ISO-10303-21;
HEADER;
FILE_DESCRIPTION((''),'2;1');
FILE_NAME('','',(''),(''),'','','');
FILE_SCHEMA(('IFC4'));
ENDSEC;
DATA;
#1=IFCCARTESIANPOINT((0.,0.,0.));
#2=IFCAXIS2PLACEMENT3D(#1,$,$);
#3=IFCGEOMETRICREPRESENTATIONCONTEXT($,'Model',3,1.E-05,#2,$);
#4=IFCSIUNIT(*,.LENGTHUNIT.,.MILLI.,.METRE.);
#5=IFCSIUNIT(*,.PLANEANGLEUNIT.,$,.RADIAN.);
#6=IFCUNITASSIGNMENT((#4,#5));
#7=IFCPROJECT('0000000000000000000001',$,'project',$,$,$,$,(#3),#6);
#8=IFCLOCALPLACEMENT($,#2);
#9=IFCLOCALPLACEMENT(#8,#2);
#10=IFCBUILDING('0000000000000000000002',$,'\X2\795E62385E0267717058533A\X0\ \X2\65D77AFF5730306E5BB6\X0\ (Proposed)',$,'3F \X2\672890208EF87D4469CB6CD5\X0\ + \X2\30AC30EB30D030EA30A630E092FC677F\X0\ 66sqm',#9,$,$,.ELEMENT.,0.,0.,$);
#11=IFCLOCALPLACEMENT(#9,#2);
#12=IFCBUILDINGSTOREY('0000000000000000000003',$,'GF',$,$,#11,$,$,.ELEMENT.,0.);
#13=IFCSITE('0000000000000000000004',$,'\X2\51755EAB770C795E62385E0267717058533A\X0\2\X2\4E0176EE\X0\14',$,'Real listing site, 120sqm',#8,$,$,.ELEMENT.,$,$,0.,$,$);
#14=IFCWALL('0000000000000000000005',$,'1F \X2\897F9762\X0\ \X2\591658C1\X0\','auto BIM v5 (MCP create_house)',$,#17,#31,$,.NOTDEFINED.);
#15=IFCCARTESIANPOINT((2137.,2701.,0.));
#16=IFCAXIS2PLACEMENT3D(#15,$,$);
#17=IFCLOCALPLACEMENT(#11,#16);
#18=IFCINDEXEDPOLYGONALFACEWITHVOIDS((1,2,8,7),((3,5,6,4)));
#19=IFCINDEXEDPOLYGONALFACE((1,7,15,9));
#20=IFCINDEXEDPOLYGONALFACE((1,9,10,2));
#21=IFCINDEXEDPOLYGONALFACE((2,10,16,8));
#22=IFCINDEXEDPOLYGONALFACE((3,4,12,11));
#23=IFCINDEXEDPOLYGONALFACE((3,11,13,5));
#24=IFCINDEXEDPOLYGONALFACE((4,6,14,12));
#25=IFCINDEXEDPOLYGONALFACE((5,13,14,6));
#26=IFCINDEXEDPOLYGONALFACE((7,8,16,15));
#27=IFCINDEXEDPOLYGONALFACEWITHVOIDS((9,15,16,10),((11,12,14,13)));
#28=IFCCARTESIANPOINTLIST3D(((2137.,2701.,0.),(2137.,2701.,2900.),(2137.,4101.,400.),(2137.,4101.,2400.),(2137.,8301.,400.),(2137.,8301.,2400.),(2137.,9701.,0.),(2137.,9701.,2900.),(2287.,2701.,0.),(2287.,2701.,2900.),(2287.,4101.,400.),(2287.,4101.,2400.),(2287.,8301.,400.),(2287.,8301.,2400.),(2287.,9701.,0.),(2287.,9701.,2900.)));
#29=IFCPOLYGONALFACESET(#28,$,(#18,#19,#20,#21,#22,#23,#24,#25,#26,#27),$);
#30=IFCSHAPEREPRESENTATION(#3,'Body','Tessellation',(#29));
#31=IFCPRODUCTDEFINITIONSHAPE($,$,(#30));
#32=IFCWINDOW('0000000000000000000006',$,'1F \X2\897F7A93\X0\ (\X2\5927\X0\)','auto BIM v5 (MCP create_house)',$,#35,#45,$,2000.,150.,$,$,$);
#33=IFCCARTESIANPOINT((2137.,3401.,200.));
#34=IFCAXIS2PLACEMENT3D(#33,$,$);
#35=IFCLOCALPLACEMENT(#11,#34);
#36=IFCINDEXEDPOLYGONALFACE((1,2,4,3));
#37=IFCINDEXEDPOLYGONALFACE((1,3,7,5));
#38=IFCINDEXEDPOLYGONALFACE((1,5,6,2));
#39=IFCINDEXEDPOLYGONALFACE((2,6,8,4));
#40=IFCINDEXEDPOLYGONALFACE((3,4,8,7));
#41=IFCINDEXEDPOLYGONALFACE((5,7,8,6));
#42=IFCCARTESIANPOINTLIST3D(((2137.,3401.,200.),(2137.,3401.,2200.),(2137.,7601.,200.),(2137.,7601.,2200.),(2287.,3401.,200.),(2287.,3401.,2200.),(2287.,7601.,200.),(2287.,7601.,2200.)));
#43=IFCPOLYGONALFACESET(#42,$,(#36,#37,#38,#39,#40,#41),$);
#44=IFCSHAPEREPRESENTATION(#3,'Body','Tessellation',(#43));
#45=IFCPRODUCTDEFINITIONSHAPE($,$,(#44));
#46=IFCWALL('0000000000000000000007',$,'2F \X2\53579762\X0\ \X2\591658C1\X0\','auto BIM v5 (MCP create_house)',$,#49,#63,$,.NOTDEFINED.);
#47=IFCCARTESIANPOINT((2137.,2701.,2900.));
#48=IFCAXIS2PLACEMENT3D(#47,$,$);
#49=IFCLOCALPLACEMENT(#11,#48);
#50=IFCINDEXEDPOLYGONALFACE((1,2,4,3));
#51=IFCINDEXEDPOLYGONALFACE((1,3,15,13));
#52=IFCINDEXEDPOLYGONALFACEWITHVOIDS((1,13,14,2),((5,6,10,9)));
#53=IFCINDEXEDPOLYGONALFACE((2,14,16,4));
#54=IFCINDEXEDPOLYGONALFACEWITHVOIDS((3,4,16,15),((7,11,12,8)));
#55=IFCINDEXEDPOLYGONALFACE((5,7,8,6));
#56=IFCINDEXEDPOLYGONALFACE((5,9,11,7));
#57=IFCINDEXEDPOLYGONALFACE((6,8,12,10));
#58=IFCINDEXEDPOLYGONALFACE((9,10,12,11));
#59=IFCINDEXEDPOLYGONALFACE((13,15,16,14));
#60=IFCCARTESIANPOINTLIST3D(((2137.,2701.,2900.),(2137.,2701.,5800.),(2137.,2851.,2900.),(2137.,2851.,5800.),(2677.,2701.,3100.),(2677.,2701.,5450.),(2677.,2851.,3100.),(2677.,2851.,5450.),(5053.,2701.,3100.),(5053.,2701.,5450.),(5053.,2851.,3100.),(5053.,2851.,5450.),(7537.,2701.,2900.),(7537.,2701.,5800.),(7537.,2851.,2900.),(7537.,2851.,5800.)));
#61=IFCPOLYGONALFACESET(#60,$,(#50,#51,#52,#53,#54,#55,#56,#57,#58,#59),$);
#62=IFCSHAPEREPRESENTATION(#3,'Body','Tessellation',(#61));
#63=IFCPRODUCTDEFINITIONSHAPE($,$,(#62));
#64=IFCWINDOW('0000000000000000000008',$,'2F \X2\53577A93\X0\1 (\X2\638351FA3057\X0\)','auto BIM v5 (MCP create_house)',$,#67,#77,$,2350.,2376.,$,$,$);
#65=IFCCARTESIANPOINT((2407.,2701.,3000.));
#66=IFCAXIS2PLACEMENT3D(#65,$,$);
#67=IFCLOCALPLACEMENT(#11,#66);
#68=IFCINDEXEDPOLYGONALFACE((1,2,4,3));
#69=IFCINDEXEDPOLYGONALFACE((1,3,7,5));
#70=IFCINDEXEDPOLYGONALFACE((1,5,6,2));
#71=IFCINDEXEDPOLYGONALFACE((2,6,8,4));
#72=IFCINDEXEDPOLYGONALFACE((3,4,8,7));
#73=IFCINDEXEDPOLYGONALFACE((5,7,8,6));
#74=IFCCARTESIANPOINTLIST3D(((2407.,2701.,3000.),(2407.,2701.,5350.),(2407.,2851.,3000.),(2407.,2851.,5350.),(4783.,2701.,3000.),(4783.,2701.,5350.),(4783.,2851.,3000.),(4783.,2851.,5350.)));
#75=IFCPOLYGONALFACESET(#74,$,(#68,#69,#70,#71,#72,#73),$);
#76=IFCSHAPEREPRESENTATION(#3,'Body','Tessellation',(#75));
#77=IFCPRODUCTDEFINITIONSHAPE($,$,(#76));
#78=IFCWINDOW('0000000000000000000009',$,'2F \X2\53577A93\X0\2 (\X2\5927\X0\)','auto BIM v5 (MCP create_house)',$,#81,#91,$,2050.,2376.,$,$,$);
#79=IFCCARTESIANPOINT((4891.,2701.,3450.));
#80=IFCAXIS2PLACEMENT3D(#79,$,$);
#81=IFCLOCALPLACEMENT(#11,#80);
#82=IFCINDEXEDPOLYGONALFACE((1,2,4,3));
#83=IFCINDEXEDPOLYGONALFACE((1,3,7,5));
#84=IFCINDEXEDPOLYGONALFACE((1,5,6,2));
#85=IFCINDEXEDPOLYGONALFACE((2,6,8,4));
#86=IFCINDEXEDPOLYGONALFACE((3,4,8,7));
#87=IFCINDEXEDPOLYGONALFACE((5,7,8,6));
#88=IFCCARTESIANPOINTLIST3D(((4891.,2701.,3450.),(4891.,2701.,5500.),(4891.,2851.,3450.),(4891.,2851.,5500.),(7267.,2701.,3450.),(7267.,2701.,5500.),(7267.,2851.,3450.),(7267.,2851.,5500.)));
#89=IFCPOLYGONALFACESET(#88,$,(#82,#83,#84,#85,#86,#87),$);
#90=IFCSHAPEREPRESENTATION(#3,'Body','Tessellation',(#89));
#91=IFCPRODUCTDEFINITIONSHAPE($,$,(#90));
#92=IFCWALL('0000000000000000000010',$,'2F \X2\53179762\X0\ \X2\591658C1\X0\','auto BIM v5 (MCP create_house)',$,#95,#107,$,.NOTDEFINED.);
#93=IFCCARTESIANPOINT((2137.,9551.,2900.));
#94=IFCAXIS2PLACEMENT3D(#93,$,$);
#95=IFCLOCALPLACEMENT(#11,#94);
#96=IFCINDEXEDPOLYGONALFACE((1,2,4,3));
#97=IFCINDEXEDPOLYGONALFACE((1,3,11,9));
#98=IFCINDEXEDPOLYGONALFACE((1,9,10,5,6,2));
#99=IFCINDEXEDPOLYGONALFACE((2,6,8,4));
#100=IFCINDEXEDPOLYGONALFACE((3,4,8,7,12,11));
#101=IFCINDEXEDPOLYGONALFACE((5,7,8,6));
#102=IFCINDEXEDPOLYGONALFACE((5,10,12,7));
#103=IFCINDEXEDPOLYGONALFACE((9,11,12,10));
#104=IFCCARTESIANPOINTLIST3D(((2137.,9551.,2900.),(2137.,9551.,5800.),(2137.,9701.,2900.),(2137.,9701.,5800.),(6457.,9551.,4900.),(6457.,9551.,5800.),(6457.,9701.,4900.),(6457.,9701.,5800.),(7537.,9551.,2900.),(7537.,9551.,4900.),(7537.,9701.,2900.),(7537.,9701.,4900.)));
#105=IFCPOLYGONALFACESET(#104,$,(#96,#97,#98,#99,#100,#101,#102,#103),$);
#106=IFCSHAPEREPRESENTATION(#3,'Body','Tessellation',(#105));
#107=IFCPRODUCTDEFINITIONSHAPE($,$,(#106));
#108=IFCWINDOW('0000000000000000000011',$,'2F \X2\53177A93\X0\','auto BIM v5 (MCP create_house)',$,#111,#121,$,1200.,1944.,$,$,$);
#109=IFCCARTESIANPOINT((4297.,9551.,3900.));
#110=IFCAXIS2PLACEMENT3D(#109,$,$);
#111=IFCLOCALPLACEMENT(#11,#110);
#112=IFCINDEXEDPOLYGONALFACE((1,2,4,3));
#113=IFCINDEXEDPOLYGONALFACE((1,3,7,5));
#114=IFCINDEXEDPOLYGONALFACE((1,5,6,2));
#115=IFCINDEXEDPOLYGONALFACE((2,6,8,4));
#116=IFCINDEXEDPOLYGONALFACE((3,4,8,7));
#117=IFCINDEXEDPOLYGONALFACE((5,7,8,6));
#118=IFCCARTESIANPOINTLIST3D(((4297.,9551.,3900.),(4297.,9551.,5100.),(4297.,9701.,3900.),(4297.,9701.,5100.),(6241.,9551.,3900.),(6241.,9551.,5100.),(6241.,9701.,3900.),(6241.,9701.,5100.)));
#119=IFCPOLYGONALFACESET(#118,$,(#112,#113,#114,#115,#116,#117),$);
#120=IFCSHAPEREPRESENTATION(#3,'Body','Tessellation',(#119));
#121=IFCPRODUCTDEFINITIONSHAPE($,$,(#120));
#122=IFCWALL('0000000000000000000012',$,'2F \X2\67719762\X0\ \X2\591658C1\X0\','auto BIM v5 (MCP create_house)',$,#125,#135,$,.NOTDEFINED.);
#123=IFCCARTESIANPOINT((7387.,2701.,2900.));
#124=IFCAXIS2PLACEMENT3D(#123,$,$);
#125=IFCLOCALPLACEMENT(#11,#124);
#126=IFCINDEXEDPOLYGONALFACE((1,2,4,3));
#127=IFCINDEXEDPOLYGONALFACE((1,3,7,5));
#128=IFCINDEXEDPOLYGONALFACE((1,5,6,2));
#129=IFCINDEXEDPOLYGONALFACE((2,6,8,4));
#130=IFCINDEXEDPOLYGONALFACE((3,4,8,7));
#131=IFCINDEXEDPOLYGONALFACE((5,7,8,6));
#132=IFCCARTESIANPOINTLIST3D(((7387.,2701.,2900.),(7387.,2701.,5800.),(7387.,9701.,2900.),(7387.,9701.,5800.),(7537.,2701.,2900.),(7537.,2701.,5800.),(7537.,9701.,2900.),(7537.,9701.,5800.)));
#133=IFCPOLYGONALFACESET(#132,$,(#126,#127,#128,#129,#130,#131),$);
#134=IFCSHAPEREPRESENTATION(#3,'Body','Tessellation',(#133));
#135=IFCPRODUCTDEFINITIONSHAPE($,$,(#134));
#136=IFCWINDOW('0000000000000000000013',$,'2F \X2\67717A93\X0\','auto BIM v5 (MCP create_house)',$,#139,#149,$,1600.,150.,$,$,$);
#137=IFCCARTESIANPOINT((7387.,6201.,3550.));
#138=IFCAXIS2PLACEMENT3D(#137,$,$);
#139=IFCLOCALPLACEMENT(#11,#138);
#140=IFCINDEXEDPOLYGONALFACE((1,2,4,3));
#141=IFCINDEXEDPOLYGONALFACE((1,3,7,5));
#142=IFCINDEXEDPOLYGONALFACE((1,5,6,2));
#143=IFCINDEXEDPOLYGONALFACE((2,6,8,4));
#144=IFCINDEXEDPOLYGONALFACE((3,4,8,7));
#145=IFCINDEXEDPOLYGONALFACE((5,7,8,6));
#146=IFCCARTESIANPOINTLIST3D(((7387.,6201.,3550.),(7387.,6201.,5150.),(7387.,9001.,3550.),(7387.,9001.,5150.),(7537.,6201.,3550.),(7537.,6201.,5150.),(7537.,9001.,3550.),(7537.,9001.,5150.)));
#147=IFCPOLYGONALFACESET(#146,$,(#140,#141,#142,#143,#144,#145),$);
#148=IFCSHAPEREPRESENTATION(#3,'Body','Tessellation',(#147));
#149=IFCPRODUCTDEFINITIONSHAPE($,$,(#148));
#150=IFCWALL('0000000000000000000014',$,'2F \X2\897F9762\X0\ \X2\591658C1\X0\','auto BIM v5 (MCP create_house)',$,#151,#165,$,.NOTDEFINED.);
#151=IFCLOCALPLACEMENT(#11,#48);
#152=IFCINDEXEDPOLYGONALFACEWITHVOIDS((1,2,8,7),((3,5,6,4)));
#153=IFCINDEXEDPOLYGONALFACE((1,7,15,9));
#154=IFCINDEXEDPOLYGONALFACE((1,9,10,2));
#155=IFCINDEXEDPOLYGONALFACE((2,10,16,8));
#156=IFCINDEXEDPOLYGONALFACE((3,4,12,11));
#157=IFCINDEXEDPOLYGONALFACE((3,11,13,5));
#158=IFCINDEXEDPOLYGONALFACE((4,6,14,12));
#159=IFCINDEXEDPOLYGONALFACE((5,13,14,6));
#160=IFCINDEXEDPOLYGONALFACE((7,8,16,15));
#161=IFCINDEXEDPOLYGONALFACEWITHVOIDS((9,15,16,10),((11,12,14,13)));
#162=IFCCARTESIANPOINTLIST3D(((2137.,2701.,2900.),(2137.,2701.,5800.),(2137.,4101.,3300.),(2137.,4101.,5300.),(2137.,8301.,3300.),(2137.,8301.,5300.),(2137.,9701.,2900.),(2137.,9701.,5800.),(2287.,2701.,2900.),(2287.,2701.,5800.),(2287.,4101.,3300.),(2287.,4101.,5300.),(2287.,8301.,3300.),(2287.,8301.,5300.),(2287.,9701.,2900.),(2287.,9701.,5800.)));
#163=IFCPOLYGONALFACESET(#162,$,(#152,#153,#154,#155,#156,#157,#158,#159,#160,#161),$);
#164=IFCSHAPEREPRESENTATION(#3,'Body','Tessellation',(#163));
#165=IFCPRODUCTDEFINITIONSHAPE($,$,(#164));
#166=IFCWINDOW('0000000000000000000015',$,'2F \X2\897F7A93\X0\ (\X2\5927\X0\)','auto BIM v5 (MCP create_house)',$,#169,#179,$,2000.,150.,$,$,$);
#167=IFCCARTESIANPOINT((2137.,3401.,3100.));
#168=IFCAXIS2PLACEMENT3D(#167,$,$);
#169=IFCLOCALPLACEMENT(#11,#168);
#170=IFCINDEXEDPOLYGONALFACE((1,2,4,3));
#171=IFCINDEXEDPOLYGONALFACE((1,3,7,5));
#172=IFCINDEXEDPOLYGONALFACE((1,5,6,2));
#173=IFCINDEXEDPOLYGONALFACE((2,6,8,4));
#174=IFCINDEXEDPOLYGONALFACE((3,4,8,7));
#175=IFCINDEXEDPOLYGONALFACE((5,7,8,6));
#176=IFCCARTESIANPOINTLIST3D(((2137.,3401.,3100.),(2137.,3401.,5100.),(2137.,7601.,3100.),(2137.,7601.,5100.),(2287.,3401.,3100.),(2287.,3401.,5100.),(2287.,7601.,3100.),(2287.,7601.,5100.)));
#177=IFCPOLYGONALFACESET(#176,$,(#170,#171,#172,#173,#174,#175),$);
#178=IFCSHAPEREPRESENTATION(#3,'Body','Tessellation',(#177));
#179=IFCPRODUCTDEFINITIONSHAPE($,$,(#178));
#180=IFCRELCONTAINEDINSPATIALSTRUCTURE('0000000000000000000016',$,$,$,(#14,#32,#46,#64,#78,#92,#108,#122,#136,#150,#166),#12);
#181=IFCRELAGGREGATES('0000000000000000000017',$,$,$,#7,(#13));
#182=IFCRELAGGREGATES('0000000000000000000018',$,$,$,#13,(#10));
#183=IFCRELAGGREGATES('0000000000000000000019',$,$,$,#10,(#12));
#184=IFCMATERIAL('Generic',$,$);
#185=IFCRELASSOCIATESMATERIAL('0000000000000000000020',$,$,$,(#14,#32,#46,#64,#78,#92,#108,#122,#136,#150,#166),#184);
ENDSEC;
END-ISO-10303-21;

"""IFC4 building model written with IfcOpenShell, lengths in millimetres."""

from ifc_helpers import new_model, si_unit, frame, frame_2d, origin, place, context, project, spatial, rectangle, extrude, material, element, fill, save


model = new_model("IFC4")

# Units and contexts
model_context = context("Model", 3, precision=1e-05, world=origin())
ifc_project = project(units=[si_unit("LENGTHUNIT", "METRE", prefix="MILLI"), si_unit("PLANEANGLEUNIT", "RADIAN")], contexts=[model_context])

# Site, building, storey
site_placement = place(None, origin())
site = spatial("IfcSite", under=ifc_project, at=site_placement, Name="兵庫県神戸市東灘区2丁目14", ObjectType="Real listing site, 120sqm", CompositionType="ELEMENT", RefElevation=0.0)
building_placement = place(site_placement, origin())
building = spatial("IfcBuilding", under=site, at=building_placement, Name="神戸市東灘区 旗竿地の家 (Proposed)", ObjectType="3F 木造軸組構法 + ガルバリウム鋼板 66sqm", CompositionType="ELEMENT", ElevationOfRefHeight=0.0, ElevationOfTerrain=0.0)
storey_placement = place(building_placement, origin())
storey = spatial("IfcBuildingStorey", under=building, at=storey_placement, Name="GF", CompositionType="ELEMENT", Elevation=0.0)

# Shared definitions
ifc_material = material(Name="Generic")

# Wall, opening, window
wall_1_placement = place(storey_placement, frame((2137.0, 2701.0, 0.0)))
wall_1 = element("IfcWall", 1, at=wall_1_placement, inside=storey, material=ifc_material, Name="1F 西面 外壁", Description="auto BIM v5 (MCP create_house)", PredefinedType="NOTDEFINED", context=model_context, shape_type="SweptSolid", body=[
    extrude(rectangle(XDim=150.0, YDim=7000.0, at=frame_2d((75.0, 3500.0))), frame((2137.0, 2701.0, 0.0)), (0.0, 0.0, 1.0), 2900.0),
])
opening_1_placement = place(storey_placement, frame((2137.0, 3401.0, 200.0)))
opening_1 = element("IfcOpeningElement", 2, at=opening_1_placement, cuts=wall_1, PredefinedType="NOTDEFINED", context=model_context, shape_type="SweptSolid", body=[
    extrude(rectangle(XDim=150.0, YDim=4200.0, at=frame_2d((75.0, 2100.0))), frame((2137.0, 3401.0, 200.0)), (0.0, 0.0, 1.0), 2000.0),
])
window_1_placement = place(storey_placement, frame((2137.0, 3401.0, 200.0)))
window_1 = element("IfcWindow", 3, at=window_1_placement, inside=storey, material=ifc_material, Name="1F 西窓 (大)", Description="auto BIM v5 (MCP create_house)", OverallHeight=2000.0, OverallWidth=150.0, context=model_context, shape_type="SweptSolid", body=[
    extrude(rectangle(XDim=150.0, YDim=4200.0, at=frame_2d((75.0, 2100.0))), frame((2137.0, 3401.0, 200.0)), (0.0, 0.0, 1.0), 2000.0),
])
fill(opening_1, window_1)

# Wall, openings, windows
wall_2_placement = place(storey_placement, frame((2137.0, 2701.0, 2900.0)))
wall_2 = element("IfcWall", 4, at=wall_2_placement, inside=storey, material=ifc_material, Name="2F 南面 外壁", Description="auto BIM v5 (MCP create_house)", PredefinedType="NOTDEFINED", context=model_context, shape_type="SweptSolid", body=[
    extrude(rectangle(XDim=5400.0, YDim=150.0, at=frame_2d((2700.0, 75.0))), frame((2137.0, 2701.0, 2900.0)), (0.0, 0.0, 1.0), 2900.0),
])
opening_2_placement = place(storey_placement, frame((2407.0, 2701.0, 3000.0)))
opening_2 = element("IfcOpeningElement", 5, at=opening_2_placement, cuts=wall_2, PredefinedType="NOTDEFINED", context=model_context, shape_type="SweptSolid", body=[
    extrude(rectangle(XDim=2376.0, YDim=150.0, at=frame_2d((1188.0, 75.0))), frame((2407.0, 2701.0, 3000.0)), (0.0, 0.0, 1.0), 2350.0),
])
opening_3_placement = place(storey_placement, frame((4891.0, 2701.0, 3450.0)))
opening_3 = element("IfcOpeningElement", 6, at=opening_3_placement, cuts=wall_2, PredefinedType="NOTDEFINED", context=model_context, shape_type="SweptSolid", body=[
    extrude(rectangle(XDim=2376.0, YDim=150.0, at=frame_2d((1188.0, 75.0))), frame((4891.0, 2701.0, 3450.0)), (0.0, 0.0, 1.0), 2050.0),
])
window_2_placement = place(storey_placement, frame((2407.0, 2701.0, 3000.0)))
window_2 = element("IfcWindow", 7, at=window_2_placement, inside=storey, material=ifc_material, Name="2F 南窓1 (掃出し)", Description="auto BIM v5 (MCP create_house)", OverallHeight=2350.0, OverallWidth=2376.0, context=model_context, shape_type="SweptSolid", body=[
    extrude(rectangle(XDim=2376.0, YDim=150.0, at=frame_2d((1188.0, 75.0))), frame((2407.0, 2701.0, 3000.0)), (0.0, 0.0, 1.0), 2350.0),
])
fill(opening_2, window_2)
window_3_placement = place(storey_placement, frame((4891.0, 2701.0, 3450.0)))
window_3 = element("IfcWindow", 8, at=window_3_placement, inside=storey, material=ifc_material, Name="2F 南窓2 (大)", Description="auto BIM v5 (MCP create_house)", OverallHeight=2050.0, OverallWidth=2376.0, context=model_context, shape_type="SweptSolid", body=[
    extrude(rectangle(XDim=2376.0, YDim=150.0, at=frame_2d((1188.0, 75.0))), frame((4891.0, 2701.0, 3450.0)), (0.0, 0.0, 1.0), 2050.0),
])
fill(opening_3, window_3)

# Walls, openings, windows
wall_3_placement = place(storey_placement, frame((2137.0, 9551.0, 2900.0)))
wall_3 = element("IfcWall", 9, at=wall_3_placement, inside=storey, material=ifc_material, Name="2F 北面 外壁", Description="auto BIM v5 (MCP create_house)", PredefinedType="NOTDEFINED", context=model_context, shape_type="SweptSolid", body=[
    extrude(rectangle(XDim=5400.0, YDim=150.0, at=frame_2d((2700.0, 75.0))), frame((2137.0, 9551.0, 2900.0)), (0.0, 0.0, 1.0), 2900.0),
])
opening_4_placement = place(storey_placement, frame((4297.0, 9551.0, 3900.0)))
opening_4 = element("IfcOpeningElement", 10, at=opening_4_placement, cuts=wall_3, PredefinedType="NOTDEFINED", context=model_context, shape_type="SweptSolid", body=[
    extrude(rectangle(XDim=1944.0, YDim=150.0, at=frame_2d((972.0, 75.0))), frame((4297.0, 9551.0, 3900.0)), (0.0, 0.0, 1.0), 1200.0),
])
window_4_placement = place(storey_placement, frame((4297.0, 9551.0, 3900.0)))
window_4 = element("IfcWindow", 11, at=window_4_placement, inside=storey, material=ifc_material, Name="2F 北窓", Description="auto BIM v5 (MCP create_house)", OverallHeight=1200.0, OverallWidth=1944.0, context=model_context, shape_type="SweptSolid", body=[
    extrude(rectangle(XDim=1944.0, YDim=150.0, at=frame_2d((972.0, 75.0))), frame((4297.0, 9551.0, 3900.0)), (0.0, 0.0, 1.0), 1200.0),
])
fill(opening_4, window_4)
wall_4_placement = place(storey_placement, frame((7387.0, 2701.0, 2900.0)))
wall_4 = element("IfcWall", 12, at=wall_4_placement, inside=storey, material=ifc_material, Name="2F 東面 外壁", Description="auto BIM v5 (MCP create_house)", PredefinedType="NOTDEFINED", context=model_context, shape_type="SweptSolid", body=[
    extrude(rectangle(XDim=150.0, YDim=7000.0, at=frame_2d((75.0, 3500.0))), frame((7387.0, 2701.0, 2900.0)), (0.0, 0.0, 1.0), 2900.0),
])
opening_5_placement = place(storey_placement, frame((7387.0, 6201.0, 3550.0)))
opening_5 = element("IfcOpeningElement", 13, at=opening_5_placement, cuts=wall_4, PredefinedType="NOTDEFINED", context=model_context, shape_type="SweptSolid", body=[
    extrude(rectangle(XDim=150.0, YDim=2800.0, at=frame_2d((75.0, 1400.0))), frame((7387.0, 6201.0, 3550.0)), (0.0, 0.0, 1.0), 1600.0),
])
window_5_placement = place(storey_placement, frame((7387.0, 6201.0, 3550.0)))
window_5 = element("IfcWindow", 14, at=window_5_placement, inside=storey, material=ifc_material, Name="2F 東窓", Description="auto BIM v5 (MCP create_house)", OverallHeight=1600.0, OverallWidth=150.0, context=model_context, shape_type="SweptSolid", body=[
    extrude(rectangle(XDim=150.0, YDim=2800.0, at=frame_2d((75.0, 1400.0))), frame((7387.0, 6201.0, 3550.0)), (0.0, 0.0, 1.0), 1600.0),
])
fill(opening_5, window_5)
wall_5_placement = place(storey_placement, frame((2137.0, 2701.0, 2900.0)))
wall_5 = element("IfcWall", 15, at=wall_5_placement, inside=storey, material=ifc_material, Name="2F 西面 外壁", Description="auto BIM v5 (MCP create_house)", PredefinedType="NOTDEFINED", context=model_context, shape_type="SweptSolid", body=[
    extrude(rectangle(XDim=150.0, YDim=7000.0, at=frame_2d((75.0, 3500.0))), frame((2137.0, 2701.0, 2900.0)), (0.0, 0.0, 1.0), 2900.0),
])
opening_6_placement = place(storey_placement, frame((2137.0, 3401.0, 3100.0)))
opening_6 = element("IfcOpeningElement", 16, at=opening_6_placement, cuts=wall_5, PredefinedType="NOTDEFINED", context=model_context, shape_type="SweptSolid", body=[
    extrude(rectangle(XDim=150.0, YDim=4200.0, at=frame_2d((75.0, 2100.0))), frame((2137.0, 3401.0, 3100.0)), (0.0, 0.0, 1.0), 2000.0),
])
window_6_placement = place(storey_placement, frame((2137.0, 3401.0, 3100.0)))
window_6 = element("IfcWindow", 17, at=window_6_placement, inside=storey, material=ifc_material, Name="2F 西窓 (大)", Description="auto BIM v5 (MCP create_house)", OverallHeight=2000.0, OverallWidth=150.0, context=model_context, shape_type="SweptSolid", body=[
    extrude(rectangle(XDim=150.0, YDim=4200.0, at=frame_2d((75.0, 2100.0))), frame((2137.0, 3401.0, 3100.0)), (0.0, 0.0, 1.0), 2000.0),
])
fill(opening_6, window_6)

save(model, "model.ifc")
